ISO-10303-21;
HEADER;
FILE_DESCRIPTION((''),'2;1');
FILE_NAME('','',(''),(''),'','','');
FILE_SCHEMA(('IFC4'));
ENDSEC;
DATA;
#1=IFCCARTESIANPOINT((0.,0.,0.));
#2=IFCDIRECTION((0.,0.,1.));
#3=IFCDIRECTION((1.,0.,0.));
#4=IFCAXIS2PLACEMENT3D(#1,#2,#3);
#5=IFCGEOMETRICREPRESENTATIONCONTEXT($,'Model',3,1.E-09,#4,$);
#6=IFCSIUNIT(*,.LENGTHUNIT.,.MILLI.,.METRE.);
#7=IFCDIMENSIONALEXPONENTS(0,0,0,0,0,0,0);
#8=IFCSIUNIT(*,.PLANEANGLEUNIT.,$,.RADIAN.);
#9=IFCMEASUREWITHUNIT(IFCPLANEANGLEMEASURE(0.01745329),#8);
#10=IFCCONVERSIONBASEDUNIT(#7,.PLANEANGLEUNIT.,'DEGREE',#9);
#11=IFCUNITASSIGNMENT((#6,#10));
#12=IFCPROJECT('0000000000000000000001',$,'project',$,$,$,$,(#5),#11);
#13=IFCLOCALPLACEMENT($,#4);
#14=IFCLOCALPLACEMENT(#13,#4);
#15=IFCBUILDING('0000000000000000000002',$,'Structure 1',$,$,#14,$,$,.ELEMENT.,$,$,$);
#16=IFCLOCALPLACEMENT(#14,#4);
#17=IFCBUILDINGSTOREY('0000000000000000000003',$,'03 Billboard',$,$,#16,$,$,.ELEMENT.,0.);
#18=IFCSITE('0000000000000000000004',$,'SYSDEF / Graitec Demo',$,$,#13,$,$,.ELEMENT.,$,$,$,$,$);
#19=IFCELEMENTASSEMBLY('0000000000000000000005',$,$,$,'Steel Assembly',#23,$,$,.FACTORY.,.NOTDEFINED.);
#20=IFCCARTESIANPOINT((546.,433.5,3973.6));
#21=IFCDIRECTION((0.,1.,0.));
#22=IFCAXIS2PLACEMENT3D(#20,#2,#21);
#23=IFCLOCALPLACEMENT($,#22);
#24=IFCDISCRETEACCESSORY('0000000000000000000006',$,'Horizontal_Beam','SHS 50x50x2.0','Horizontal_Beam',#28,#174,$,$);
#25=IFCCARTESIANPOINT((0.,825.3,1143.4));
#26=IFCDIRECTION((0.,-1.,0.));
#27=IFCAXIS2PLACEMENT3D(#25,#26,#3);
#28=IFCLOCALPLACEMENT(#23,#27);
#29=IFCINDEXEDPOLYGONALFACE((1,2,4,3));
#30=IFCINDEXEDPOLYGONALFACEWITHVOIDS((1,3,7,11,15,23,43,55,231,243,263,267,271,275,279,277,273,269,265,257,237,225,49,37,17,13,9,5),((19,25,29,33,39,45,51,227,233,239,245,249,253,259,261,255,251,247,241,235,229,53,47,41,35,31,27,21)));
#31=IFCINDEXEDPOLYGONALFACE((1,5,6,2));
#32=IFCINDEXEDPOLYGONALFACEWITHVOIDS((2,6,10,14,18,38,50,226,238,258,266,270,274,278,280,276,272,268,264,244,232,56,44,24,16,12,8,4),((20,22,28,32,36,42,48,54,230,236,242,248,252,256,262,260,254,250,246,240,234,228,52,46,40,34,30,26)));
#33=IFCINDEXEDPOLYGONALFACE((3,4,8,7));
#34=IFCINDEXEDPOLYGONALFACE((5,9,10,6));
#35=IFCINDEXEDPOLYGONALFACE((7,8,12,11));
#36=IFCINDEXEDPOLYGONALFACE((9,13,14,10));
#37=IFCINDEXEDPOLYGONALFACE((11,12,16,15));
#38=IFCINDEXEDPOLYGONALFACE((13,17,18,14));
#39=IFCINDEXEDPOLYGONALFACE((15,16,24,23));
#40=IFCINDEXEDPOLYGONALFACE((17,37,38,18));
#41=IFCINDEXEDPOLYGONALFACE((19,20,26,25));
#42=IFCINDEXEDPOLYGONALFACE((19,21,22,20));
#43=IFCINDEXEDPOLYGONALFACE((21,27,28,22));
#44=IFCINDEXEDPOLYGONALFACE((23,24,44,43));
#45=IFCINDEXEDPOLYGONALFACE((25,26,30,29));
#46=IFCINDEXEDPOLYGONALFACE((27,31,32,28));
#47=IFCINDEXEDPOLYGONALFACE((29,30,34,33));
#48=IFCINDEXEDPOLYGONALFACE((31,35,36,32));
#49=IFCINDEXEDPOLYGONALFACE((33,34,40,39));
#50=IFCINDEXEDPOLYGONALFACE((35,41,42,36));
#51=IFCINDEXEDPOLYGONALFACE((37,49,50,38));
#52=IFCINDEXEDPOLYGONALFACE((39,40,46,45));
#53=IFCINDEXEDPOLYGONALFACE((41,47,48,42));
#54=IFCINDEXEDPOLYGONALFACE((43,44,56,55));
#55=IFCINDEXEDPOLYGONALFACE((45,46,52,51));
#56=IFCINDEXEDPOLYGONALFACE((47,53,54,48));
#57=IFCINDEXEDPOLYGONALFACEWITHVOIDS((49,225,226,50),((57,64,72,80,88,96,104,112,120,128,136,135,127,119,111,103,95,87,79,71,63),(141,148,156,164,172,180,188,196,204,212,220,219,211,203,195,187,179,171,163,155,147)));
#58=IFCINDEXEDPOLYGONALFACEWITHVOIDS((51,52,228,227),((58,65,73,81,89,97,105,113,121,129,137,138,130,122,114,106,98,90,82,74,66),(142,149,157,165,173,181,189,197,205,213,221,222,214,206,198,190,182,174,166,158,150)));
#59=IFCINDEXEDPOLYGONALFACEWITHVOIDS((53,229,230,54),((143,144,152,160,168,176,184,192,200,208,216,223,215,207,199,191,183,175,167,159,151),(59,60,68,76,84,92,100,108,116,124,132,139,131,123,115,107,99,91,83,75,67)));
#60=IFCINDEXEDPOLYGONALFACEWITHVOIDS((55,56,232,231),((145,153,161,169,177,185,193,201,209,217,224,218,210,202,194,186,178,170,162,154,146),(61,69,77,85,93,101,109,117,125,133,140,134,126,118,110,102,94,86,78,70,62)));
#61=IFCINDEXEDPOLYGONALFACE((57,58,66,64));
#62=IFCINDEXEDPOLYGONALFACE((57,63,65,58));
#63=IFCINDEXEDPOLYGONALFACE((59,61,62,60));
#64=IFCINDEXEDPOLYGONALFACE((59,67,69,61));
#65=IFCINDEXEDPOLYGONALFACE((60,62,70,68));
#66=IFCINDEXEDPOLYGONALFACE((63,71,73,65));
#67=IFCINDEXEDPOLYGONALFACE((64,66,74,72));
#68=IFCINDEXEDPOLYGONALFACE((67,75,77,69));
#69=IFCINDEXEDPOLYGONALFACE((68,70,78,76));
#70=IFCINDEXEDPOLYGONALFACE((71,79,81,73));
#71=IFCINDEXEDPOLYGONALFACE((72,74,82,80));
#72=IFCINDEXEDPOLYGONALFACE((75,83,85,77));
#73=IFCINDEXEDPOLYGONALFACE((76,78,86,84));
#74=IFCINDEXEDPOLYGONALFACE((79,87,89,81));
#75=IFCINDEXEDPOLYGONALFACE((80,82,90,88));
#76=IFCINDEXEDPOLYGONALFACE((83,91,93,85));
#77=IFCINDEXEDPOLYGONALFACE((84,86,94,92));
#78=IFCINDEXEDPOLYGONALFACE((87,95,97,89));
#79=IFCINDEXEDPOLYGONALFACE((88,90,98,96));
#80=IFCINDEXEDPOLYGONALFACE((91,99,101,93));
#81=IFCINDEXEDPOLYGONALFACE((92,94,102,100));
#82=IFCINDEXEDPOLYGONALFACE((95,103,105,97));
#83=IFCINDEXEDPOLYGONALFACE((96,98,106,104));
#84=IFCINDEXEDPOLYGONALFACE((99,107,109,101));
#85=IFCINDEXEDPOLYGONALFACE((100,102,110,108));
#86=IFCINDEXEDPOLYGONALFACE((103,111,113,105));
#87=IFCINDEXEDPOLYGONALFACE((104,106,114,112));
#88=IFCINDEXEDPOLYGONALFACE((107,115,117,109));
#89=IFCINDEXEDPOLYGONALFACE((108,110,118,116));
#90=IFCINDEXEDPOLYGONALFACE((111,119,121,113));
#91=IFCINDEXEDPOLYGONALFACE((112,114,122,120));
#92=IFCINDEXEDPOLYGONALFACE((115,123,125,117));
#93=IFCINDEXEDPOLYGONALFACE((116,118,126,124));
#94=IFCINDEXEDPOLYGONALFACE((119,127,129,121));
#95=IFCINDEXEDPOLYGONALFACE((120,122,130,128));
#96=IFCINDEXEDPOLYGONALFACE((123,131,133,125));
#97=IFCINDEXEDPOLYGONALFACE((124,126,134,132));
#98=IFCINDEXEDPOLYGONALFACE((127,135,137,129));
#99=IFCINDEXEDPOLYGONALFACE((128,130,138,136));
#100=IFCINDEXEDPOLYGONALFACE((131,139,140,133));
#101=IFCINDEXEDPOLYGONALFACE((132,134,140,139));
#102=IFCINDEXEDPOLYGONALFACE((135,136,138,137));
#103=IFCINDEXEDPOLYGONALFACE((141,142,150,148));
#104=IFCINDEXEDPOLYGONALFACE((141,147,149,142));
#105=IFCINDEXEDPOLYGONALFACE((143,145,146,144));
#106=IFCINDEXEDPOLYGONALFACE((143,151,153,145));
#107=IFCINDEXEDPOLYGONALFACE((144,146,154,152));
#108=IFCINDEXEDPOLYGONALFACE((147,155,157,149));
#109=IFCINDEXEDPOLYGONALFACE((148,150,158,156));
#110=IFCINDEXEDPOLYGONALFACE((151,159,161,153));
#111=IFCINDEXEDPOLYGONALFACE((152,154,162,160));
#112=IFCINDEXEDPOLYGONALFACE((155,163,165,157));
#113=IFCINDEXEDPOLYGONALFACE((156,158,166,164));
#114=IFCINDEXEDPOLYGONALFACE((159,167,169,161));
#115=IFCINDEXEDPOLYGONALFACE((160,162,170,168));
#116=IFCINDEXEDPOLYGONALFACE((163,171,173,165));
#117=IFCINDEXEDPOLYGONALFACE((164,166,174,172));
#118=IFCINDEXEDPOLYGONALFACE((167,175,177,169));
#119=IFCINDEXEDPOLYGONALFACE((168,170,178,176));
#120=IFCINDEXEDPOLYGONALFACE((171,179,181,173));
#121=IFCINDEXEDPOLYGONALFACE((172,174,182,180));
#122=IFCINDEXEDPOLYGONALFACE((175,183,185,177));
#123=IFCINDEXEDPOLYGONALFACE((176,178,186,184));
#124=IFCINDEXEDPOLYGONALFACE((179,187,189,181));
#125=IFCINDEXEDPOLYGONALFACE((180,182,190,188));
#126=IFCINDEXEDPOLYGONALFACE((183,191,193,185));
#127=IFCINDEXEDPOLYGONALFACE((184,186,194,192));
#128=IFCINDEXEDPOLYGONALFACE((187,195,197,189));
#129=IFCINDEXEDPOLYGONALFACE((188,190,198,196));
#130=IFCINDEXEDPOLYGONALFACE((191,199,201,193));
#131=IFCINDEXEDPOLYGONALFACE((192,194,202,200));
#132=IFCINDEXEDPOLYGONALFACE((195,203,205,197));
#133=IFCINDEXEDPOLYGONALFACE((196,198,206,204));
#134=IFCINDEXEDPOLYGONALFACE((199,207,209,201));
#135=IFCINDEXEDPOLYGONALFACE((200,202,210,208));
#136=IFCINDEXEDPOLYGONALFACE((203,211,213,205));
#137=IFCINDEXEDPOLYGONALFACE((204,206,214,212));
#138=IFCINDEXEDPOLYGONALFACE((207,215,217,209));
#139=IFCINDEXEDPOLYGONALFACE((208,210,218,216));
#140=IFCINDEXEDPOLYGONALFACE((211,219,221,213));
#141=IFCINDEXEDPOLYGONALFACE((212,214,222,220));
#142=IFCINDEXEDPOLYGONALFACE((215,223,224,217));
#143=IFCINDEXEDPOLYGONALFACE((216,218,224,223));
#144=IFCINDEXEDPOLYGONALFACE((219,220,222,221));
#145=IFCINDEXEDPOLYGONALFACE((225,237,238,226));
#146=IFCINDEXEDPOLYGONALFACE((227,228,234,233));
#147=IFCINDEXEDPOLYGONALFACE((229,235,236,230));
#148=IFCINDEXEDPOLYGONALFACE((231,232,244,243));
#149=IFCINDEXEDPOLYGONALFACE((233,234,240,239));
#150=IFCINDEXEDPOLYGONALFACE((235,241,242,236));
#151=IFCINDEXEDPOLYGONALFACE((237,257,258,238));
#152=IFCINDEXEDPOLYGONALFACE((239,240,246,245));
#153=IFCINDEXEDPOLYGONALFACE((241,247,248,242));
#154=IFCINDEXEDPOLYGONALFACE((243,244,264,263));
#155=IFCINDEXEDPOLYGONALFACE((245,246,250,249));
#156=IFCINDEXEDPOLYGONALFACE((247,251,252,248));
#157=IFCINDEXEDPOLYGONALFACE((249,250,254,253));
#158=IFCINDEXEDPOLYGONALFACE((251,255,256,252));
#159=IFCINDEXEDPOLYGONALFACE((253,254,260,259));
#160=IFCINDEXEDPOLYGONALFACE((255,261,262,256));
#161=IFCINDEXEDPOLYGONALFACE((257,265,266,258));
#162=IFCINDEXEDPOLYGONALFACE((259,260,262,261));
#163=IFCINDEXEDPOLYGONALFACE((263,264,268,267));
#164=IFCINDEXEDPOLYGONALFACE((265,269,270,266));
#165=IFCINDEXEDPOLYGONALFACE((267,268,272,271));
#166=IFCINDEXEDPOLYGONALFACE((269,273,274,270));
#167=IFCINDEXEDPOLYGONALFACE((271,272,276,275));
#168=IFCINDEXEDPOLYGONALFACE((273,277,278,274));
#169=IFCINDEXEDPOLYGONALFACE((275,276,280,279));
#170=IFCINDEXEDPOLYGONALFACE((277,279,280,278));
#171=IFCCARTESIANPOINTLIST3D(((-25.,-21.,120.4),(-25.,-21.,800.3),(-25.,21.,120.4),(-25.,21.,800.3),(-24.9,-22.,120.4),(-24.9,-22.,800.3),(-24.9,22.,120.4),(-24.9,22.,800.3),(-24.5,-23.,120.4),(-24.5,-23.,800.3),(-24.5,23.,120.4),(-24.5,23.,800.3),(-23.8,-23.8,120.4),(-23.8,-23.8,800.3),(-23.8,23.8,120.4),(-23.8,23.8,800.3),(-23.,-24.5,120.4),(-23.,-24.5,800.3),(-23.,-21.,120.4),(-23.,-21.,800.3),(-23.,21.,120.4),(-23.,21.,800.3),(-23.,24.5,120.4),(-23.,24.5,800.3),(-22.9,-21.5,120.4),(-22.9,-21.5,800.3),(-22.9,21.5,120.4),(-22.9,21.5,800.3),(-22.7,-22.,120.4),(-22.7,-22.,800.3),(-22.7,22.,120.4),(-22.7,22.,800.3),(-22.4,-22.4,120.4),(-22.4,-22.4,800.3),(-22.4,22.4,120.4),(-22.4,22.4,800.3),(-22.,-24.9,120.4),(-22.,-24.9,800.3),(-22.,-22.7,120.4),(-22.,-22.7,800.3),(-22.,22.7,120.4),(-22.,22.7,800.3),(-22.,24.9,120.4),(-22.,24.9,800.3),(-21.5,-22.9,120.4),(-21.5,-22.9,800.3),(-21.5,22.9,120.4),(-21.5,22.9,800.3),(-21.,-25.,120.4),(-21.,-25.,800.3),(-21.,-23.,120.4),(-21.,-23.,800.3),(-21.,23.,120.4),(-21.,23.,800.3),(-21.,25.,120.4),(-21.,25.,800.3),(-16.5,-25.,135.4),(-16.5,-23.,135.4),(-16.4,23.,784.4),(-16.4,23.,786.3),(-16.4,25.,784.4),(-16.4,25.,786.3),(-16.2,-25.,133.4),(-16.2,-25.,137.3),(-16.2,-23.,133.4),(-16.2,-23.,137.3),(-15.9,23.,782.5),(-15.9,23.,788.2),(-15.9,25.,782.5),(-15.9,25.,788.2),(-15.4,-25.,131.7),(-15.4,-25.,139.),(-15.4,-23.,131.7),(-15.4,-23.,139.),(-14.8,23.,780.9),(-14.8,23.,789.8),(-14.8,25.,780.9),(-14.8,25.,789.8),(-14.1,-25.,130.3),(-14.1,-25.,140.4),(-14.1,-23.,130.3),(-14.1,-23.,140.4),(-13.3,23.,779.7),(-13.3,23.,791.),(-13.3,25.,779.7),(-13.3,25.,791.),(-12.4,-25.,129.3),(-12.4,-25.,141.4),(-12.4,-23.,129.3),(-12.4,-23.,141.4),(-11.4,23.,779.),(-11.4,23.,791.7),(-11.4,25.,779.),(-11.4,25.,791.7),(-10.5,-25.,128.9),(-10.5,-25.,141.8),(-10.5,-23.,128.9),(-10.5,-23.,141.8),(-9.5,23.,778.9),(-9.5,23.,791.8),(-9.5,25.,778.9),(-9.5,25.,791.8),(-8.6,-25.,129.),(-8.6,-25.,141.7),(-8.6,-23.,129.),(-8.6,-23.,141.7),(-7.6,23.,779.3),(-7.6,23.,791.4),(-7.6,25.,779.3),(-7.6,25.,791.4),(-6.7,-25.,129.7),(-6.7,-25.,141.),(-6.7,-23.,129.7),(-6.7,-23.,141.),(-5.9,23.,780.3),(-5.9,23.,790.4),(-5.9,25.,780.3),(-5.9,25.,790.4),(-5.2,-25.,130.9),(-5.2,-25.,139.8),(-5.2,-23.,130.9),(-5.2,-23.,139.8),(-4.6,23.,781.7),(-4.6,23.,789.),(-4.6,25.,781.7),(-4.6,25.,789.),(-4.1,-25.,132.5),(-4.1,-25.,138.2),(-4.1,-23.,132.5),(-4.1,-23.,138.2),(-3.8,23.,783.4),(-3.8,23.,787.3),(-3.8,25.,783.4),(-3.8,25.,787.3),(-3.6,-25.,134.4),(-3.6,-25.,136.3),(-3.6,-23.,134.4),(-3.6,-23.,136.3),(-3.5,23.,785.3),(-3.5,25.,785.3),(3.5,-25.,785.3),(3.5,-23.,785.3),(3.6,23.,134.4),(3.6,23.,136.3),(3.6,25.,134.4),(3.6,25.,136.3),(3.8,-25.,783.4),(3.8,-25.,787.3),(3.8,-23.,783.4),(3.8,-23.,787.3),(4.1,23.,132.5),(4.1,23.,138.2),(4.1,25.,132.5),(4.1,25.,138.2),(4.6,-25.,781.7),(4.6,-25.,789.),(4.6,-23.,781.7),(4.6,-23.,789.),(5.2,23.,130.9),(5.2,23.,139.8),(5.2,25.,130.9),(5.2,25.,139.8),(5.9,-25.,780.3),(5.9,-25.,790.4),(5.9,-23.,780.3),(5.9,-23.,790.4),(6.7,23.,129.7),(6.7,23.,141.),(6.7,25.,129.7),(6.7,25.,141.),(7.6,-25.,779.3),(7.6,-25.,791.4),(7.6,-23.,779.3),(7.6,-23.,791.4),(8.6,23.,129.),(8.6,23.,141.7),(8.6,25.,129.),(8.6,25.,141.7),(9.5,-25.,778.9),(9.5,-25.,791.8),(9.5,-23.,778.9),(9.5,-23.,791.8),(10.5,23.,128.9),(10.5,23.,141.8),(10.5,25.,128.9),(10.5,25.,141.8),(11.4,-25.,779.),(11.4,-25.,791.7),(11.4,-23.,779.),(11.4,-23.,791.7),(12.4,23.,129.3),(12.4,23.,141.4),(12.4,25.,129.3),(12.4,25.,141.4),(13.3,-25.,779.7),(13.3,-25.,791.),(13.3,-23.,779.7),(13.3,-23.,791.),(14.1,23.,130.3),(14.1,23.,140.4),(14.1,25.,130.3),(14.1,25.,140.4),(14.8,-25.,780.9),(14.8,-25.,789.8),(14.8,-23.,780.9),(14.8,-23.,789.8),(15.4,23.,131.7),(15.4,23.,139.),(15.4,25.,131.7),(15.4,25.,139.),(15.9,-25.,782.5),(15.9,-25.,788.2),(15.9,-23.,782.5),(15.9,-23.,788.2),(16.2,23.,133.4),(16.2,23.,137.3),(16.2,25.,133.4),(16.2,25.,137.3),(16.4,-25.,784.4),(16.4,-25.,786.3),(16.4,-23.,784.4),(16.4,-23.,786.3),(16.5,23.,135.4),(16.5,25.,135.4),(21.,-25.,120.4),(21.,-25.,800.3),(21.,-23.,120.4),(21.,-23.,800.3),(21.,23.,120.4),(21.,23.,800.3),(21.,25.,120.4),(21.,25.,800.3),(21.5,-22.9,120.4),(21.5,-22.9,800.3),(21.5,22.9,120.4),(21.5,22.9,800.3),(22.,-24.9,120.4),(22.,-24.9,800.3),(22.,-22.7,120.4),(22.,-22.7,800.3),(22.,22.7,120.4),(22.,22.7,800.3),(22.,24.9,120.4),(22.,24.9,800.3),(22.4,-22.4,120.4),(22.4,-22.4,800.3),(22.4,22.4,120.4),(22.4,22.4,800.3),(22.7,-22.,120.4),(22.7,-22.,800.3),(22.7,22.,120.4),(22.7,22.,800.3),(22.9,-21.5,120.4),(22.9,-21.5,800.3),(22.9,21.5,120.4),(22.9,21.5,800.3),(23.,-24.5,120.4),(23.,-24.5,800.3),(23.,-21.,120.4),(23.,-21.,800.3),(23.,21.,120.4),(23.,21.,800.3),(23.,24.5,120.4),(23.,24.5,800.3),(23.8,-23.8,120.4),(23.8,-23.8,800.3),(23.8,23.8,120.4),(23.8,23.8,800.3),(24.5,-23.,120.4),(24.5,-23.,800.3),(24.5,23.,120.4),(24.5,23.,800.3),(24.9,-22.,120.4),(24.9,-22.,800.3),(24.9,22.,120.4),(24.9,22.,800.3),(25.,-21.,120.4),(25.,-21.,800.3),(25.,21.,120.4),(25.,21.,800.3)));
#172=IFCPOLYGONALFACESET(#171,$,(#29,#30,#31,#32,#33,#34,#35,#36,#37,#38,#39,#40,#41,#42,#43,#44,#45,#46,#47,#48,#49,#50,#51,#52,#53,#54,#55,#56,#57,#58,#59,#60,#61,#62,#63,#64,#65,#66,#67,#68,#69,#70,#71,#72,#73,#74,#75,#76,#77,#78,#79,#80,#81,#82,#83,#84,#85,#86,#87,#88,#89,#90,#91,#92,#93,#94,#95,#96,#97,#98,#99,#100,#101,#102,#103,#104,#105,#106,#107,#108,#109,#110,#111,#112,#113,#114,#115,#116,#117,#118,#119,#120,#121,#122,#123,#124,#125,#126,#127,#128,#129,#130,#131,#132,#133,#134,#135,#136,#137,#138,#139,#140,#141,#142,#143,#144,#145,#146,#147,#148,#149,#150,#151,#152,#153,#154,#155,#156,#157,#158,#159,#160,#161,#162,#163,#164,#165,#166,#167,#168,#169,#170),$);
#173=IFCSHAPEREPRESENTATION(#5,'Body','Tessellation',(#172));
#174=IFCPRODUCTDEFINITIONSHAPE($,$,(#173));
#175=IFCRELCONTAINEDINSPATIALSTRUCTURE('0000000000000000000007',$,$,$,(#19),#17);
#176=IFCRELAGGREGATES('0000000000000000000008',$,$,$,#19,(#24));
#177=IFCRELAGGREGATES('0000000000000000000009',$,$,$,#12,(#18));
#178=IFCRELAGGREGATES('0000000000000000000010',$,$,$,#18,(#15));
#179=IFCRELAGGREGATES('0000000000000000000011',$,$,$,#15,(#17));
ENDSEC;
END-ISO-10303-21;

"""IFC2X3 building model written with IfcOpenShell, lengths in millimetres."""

from ifc_helpers import new_model, entity, si_unit, converted_unit, frame, frame_2d, origin, origin_with_axes, origin_2d, place, context, project, spatial, hollow_rectangle, circle, extrude, clip, halfspace, element, aggregate, save


model = new_model("IFC2X3")

# Units and contexts
model_context = context("Model", 3, precision=1e-09, world=origin_with_axes())
ifc_project = project(units=[si_unit("LENGTHUNIT", "METRE", prefix="MILLI"), converted_unit("PLANEANGLEUNIT", "DEGREE", entity("IfcPlaneAngleMeasure", 0.01745329), si_unit("PLANEANGLEUNIT", "RADIAN"), dimensions=[0, 0, 0, 0, 0, 0, 0])], contexts=[model_context])

# Site, building, storey
site_placement = place(None, origin_with_axes())
site = spatial("IfcSite", under=ifc_project, at=site_placement, Name="SYSDEF / Graitec Demo", CompositionType="ELEMENT")
building_placement = place(site_placement, origin_with_axes())
building = spatial("IfcBuilding", under=site, at=building_placement, Name="Structure 1", CompositionType="ELEMENT")
storey_placement = place(building_placement, origin_with_axes())
storey = spatial("IfcBuildingStorey", under=building, at=storey_placement, Name="03 Billboard", CompositionType="ELEMENT", Elevation=0.0)

# Element assembly, discrete accessory, openings
assembly_1_placement = place(None, frame((546.0, 433.5, 3973.6), z_axis=(0.0, 0.0, 1.0), x_axis=(0.0, 1.0, 0.0)))
assembly_1 = element("IfcElementAssembly", 1, at=assembly_1_placement, inside=storey, ObjectType="Steel Assembly", AssemblyPlace="FACTORY", PredefinedType="NOTDEFINED")
discrete_accessory_1_placement = place(assembly_1_placement, frame((0.0, 825.3, 1143.4), z_axis=(0.0, -1.0, 0.0), x_axis=(1.0, 0.0, 0.0)))
discrete_accessory_1 = element("IfcDiscreteAccessory", 2, at=discrete_accessory_1_placement, Name="Horizontal_Beam", Description="SHS 50x50x2.0", ObjectType="Horizontal_Beam", context=model_context, shape_type="Clipping", body=[
    clip(clip(extrude(hollow_rectangle(XDim=50.0, YDim=50.0, WallThickness=2.0, InnerFilletRadius=2.0, OuterFilletRadius=4.0, at=origin_2d()), origin(), (0.0, 0.0, 1.0), 920.7), halfspace(frame((-433.5, -5117.0, 800.3), z_axis=(0.0, 0.0, -1.0), x_axis=(-1.0, 0.0, 0.0)), True)), halfspace(frame((-433.5, -5117.0, 120.4), z_axis=(0.0, 0.0, 1.0), x_axis=(1.0, 0.0, 0.0)), True)),
])
opening_1_placement = place(discrete_accessory_1_placement, frame((-10.0, -22.5, 128.9), z_axis=(0.0, 1.0, 0.0), x_axis=(-1.0, 0.0, 0.0)))
element("IfcOpeningElement", 3, at=opening_1_placement, cuts=discrete_accessory_1, ObjectType="Opening", context=model_context, shape_type="SweptSolid", body=[
    extrude(circle(Radius=6.5, at=frame_2d((0.0, 6.5), x_axis=(1.0, 0.0))), origin(), (0.0, 0.0, -1.0), 3.0),
])
opening_2_placement = place(discrete_accessory_1_placement, frame((10.0, -22.5, 791.8), z_axis=(0.0, 1.0, 0.0), x_axis=(-1.0, 0.0, 0.0)))
element("IfcOpeningElement", 4, at=opening_2_placement, cuts=discrete_accessory_1, ObjectType="Opening", context=model_context, shape_type="SweptSolid", body=[
    extrude(circle(Radius=6.5, at=frame_2d((0.0, -6.5), x_axis=(1.0, 0.0))), origin(), (0.0, 0.0, -1.0), 3.0),
])
opening_3_placement = place(discrete_accessory_1_placement, frame((10.0, 22.5, 128.9), z_axis=(0.0, -1.0, 0.0), x_axis=(1.0, 0.0, 0.0)))
element("IfcOpeningElement", 5, at=opening_3_placement, cuts=discrete_accessory_1, ObjectType="Opening", context=model_context, shape_type="SweptSolid", body=[
    extrude(circle(Radius=6.5, at=frame_2d((0.0, 6.5), x_axis=(1.0, 0.0))), origin(), (0.0, 0.0, -1.0), 3.0),
])
opening_4_placement = place(discrete_accessory_1_placement, frame((-10.0, 22.5, 791.8), z_axis=(0.0, -1.0, 0.0), x_axis=(1.0, 0.0, 0.0)))
element("IfcOpeningElement", 6, at=opening_4_placement, cuts=discrete_accessory_1, ObjectType="Opening", context=model_context, shape_type="SweptSolid", body=[
    extrude(circle(Radius=6.5, at=frame_2d((0.0, -6.5), x_axis=(1.0, 0.0))), origin(), (0.0, 0.0, -1.0), 3.0),
])
aggregate(assembly_1, [discrete_accessory_1])

save(model, "model.ifc")
